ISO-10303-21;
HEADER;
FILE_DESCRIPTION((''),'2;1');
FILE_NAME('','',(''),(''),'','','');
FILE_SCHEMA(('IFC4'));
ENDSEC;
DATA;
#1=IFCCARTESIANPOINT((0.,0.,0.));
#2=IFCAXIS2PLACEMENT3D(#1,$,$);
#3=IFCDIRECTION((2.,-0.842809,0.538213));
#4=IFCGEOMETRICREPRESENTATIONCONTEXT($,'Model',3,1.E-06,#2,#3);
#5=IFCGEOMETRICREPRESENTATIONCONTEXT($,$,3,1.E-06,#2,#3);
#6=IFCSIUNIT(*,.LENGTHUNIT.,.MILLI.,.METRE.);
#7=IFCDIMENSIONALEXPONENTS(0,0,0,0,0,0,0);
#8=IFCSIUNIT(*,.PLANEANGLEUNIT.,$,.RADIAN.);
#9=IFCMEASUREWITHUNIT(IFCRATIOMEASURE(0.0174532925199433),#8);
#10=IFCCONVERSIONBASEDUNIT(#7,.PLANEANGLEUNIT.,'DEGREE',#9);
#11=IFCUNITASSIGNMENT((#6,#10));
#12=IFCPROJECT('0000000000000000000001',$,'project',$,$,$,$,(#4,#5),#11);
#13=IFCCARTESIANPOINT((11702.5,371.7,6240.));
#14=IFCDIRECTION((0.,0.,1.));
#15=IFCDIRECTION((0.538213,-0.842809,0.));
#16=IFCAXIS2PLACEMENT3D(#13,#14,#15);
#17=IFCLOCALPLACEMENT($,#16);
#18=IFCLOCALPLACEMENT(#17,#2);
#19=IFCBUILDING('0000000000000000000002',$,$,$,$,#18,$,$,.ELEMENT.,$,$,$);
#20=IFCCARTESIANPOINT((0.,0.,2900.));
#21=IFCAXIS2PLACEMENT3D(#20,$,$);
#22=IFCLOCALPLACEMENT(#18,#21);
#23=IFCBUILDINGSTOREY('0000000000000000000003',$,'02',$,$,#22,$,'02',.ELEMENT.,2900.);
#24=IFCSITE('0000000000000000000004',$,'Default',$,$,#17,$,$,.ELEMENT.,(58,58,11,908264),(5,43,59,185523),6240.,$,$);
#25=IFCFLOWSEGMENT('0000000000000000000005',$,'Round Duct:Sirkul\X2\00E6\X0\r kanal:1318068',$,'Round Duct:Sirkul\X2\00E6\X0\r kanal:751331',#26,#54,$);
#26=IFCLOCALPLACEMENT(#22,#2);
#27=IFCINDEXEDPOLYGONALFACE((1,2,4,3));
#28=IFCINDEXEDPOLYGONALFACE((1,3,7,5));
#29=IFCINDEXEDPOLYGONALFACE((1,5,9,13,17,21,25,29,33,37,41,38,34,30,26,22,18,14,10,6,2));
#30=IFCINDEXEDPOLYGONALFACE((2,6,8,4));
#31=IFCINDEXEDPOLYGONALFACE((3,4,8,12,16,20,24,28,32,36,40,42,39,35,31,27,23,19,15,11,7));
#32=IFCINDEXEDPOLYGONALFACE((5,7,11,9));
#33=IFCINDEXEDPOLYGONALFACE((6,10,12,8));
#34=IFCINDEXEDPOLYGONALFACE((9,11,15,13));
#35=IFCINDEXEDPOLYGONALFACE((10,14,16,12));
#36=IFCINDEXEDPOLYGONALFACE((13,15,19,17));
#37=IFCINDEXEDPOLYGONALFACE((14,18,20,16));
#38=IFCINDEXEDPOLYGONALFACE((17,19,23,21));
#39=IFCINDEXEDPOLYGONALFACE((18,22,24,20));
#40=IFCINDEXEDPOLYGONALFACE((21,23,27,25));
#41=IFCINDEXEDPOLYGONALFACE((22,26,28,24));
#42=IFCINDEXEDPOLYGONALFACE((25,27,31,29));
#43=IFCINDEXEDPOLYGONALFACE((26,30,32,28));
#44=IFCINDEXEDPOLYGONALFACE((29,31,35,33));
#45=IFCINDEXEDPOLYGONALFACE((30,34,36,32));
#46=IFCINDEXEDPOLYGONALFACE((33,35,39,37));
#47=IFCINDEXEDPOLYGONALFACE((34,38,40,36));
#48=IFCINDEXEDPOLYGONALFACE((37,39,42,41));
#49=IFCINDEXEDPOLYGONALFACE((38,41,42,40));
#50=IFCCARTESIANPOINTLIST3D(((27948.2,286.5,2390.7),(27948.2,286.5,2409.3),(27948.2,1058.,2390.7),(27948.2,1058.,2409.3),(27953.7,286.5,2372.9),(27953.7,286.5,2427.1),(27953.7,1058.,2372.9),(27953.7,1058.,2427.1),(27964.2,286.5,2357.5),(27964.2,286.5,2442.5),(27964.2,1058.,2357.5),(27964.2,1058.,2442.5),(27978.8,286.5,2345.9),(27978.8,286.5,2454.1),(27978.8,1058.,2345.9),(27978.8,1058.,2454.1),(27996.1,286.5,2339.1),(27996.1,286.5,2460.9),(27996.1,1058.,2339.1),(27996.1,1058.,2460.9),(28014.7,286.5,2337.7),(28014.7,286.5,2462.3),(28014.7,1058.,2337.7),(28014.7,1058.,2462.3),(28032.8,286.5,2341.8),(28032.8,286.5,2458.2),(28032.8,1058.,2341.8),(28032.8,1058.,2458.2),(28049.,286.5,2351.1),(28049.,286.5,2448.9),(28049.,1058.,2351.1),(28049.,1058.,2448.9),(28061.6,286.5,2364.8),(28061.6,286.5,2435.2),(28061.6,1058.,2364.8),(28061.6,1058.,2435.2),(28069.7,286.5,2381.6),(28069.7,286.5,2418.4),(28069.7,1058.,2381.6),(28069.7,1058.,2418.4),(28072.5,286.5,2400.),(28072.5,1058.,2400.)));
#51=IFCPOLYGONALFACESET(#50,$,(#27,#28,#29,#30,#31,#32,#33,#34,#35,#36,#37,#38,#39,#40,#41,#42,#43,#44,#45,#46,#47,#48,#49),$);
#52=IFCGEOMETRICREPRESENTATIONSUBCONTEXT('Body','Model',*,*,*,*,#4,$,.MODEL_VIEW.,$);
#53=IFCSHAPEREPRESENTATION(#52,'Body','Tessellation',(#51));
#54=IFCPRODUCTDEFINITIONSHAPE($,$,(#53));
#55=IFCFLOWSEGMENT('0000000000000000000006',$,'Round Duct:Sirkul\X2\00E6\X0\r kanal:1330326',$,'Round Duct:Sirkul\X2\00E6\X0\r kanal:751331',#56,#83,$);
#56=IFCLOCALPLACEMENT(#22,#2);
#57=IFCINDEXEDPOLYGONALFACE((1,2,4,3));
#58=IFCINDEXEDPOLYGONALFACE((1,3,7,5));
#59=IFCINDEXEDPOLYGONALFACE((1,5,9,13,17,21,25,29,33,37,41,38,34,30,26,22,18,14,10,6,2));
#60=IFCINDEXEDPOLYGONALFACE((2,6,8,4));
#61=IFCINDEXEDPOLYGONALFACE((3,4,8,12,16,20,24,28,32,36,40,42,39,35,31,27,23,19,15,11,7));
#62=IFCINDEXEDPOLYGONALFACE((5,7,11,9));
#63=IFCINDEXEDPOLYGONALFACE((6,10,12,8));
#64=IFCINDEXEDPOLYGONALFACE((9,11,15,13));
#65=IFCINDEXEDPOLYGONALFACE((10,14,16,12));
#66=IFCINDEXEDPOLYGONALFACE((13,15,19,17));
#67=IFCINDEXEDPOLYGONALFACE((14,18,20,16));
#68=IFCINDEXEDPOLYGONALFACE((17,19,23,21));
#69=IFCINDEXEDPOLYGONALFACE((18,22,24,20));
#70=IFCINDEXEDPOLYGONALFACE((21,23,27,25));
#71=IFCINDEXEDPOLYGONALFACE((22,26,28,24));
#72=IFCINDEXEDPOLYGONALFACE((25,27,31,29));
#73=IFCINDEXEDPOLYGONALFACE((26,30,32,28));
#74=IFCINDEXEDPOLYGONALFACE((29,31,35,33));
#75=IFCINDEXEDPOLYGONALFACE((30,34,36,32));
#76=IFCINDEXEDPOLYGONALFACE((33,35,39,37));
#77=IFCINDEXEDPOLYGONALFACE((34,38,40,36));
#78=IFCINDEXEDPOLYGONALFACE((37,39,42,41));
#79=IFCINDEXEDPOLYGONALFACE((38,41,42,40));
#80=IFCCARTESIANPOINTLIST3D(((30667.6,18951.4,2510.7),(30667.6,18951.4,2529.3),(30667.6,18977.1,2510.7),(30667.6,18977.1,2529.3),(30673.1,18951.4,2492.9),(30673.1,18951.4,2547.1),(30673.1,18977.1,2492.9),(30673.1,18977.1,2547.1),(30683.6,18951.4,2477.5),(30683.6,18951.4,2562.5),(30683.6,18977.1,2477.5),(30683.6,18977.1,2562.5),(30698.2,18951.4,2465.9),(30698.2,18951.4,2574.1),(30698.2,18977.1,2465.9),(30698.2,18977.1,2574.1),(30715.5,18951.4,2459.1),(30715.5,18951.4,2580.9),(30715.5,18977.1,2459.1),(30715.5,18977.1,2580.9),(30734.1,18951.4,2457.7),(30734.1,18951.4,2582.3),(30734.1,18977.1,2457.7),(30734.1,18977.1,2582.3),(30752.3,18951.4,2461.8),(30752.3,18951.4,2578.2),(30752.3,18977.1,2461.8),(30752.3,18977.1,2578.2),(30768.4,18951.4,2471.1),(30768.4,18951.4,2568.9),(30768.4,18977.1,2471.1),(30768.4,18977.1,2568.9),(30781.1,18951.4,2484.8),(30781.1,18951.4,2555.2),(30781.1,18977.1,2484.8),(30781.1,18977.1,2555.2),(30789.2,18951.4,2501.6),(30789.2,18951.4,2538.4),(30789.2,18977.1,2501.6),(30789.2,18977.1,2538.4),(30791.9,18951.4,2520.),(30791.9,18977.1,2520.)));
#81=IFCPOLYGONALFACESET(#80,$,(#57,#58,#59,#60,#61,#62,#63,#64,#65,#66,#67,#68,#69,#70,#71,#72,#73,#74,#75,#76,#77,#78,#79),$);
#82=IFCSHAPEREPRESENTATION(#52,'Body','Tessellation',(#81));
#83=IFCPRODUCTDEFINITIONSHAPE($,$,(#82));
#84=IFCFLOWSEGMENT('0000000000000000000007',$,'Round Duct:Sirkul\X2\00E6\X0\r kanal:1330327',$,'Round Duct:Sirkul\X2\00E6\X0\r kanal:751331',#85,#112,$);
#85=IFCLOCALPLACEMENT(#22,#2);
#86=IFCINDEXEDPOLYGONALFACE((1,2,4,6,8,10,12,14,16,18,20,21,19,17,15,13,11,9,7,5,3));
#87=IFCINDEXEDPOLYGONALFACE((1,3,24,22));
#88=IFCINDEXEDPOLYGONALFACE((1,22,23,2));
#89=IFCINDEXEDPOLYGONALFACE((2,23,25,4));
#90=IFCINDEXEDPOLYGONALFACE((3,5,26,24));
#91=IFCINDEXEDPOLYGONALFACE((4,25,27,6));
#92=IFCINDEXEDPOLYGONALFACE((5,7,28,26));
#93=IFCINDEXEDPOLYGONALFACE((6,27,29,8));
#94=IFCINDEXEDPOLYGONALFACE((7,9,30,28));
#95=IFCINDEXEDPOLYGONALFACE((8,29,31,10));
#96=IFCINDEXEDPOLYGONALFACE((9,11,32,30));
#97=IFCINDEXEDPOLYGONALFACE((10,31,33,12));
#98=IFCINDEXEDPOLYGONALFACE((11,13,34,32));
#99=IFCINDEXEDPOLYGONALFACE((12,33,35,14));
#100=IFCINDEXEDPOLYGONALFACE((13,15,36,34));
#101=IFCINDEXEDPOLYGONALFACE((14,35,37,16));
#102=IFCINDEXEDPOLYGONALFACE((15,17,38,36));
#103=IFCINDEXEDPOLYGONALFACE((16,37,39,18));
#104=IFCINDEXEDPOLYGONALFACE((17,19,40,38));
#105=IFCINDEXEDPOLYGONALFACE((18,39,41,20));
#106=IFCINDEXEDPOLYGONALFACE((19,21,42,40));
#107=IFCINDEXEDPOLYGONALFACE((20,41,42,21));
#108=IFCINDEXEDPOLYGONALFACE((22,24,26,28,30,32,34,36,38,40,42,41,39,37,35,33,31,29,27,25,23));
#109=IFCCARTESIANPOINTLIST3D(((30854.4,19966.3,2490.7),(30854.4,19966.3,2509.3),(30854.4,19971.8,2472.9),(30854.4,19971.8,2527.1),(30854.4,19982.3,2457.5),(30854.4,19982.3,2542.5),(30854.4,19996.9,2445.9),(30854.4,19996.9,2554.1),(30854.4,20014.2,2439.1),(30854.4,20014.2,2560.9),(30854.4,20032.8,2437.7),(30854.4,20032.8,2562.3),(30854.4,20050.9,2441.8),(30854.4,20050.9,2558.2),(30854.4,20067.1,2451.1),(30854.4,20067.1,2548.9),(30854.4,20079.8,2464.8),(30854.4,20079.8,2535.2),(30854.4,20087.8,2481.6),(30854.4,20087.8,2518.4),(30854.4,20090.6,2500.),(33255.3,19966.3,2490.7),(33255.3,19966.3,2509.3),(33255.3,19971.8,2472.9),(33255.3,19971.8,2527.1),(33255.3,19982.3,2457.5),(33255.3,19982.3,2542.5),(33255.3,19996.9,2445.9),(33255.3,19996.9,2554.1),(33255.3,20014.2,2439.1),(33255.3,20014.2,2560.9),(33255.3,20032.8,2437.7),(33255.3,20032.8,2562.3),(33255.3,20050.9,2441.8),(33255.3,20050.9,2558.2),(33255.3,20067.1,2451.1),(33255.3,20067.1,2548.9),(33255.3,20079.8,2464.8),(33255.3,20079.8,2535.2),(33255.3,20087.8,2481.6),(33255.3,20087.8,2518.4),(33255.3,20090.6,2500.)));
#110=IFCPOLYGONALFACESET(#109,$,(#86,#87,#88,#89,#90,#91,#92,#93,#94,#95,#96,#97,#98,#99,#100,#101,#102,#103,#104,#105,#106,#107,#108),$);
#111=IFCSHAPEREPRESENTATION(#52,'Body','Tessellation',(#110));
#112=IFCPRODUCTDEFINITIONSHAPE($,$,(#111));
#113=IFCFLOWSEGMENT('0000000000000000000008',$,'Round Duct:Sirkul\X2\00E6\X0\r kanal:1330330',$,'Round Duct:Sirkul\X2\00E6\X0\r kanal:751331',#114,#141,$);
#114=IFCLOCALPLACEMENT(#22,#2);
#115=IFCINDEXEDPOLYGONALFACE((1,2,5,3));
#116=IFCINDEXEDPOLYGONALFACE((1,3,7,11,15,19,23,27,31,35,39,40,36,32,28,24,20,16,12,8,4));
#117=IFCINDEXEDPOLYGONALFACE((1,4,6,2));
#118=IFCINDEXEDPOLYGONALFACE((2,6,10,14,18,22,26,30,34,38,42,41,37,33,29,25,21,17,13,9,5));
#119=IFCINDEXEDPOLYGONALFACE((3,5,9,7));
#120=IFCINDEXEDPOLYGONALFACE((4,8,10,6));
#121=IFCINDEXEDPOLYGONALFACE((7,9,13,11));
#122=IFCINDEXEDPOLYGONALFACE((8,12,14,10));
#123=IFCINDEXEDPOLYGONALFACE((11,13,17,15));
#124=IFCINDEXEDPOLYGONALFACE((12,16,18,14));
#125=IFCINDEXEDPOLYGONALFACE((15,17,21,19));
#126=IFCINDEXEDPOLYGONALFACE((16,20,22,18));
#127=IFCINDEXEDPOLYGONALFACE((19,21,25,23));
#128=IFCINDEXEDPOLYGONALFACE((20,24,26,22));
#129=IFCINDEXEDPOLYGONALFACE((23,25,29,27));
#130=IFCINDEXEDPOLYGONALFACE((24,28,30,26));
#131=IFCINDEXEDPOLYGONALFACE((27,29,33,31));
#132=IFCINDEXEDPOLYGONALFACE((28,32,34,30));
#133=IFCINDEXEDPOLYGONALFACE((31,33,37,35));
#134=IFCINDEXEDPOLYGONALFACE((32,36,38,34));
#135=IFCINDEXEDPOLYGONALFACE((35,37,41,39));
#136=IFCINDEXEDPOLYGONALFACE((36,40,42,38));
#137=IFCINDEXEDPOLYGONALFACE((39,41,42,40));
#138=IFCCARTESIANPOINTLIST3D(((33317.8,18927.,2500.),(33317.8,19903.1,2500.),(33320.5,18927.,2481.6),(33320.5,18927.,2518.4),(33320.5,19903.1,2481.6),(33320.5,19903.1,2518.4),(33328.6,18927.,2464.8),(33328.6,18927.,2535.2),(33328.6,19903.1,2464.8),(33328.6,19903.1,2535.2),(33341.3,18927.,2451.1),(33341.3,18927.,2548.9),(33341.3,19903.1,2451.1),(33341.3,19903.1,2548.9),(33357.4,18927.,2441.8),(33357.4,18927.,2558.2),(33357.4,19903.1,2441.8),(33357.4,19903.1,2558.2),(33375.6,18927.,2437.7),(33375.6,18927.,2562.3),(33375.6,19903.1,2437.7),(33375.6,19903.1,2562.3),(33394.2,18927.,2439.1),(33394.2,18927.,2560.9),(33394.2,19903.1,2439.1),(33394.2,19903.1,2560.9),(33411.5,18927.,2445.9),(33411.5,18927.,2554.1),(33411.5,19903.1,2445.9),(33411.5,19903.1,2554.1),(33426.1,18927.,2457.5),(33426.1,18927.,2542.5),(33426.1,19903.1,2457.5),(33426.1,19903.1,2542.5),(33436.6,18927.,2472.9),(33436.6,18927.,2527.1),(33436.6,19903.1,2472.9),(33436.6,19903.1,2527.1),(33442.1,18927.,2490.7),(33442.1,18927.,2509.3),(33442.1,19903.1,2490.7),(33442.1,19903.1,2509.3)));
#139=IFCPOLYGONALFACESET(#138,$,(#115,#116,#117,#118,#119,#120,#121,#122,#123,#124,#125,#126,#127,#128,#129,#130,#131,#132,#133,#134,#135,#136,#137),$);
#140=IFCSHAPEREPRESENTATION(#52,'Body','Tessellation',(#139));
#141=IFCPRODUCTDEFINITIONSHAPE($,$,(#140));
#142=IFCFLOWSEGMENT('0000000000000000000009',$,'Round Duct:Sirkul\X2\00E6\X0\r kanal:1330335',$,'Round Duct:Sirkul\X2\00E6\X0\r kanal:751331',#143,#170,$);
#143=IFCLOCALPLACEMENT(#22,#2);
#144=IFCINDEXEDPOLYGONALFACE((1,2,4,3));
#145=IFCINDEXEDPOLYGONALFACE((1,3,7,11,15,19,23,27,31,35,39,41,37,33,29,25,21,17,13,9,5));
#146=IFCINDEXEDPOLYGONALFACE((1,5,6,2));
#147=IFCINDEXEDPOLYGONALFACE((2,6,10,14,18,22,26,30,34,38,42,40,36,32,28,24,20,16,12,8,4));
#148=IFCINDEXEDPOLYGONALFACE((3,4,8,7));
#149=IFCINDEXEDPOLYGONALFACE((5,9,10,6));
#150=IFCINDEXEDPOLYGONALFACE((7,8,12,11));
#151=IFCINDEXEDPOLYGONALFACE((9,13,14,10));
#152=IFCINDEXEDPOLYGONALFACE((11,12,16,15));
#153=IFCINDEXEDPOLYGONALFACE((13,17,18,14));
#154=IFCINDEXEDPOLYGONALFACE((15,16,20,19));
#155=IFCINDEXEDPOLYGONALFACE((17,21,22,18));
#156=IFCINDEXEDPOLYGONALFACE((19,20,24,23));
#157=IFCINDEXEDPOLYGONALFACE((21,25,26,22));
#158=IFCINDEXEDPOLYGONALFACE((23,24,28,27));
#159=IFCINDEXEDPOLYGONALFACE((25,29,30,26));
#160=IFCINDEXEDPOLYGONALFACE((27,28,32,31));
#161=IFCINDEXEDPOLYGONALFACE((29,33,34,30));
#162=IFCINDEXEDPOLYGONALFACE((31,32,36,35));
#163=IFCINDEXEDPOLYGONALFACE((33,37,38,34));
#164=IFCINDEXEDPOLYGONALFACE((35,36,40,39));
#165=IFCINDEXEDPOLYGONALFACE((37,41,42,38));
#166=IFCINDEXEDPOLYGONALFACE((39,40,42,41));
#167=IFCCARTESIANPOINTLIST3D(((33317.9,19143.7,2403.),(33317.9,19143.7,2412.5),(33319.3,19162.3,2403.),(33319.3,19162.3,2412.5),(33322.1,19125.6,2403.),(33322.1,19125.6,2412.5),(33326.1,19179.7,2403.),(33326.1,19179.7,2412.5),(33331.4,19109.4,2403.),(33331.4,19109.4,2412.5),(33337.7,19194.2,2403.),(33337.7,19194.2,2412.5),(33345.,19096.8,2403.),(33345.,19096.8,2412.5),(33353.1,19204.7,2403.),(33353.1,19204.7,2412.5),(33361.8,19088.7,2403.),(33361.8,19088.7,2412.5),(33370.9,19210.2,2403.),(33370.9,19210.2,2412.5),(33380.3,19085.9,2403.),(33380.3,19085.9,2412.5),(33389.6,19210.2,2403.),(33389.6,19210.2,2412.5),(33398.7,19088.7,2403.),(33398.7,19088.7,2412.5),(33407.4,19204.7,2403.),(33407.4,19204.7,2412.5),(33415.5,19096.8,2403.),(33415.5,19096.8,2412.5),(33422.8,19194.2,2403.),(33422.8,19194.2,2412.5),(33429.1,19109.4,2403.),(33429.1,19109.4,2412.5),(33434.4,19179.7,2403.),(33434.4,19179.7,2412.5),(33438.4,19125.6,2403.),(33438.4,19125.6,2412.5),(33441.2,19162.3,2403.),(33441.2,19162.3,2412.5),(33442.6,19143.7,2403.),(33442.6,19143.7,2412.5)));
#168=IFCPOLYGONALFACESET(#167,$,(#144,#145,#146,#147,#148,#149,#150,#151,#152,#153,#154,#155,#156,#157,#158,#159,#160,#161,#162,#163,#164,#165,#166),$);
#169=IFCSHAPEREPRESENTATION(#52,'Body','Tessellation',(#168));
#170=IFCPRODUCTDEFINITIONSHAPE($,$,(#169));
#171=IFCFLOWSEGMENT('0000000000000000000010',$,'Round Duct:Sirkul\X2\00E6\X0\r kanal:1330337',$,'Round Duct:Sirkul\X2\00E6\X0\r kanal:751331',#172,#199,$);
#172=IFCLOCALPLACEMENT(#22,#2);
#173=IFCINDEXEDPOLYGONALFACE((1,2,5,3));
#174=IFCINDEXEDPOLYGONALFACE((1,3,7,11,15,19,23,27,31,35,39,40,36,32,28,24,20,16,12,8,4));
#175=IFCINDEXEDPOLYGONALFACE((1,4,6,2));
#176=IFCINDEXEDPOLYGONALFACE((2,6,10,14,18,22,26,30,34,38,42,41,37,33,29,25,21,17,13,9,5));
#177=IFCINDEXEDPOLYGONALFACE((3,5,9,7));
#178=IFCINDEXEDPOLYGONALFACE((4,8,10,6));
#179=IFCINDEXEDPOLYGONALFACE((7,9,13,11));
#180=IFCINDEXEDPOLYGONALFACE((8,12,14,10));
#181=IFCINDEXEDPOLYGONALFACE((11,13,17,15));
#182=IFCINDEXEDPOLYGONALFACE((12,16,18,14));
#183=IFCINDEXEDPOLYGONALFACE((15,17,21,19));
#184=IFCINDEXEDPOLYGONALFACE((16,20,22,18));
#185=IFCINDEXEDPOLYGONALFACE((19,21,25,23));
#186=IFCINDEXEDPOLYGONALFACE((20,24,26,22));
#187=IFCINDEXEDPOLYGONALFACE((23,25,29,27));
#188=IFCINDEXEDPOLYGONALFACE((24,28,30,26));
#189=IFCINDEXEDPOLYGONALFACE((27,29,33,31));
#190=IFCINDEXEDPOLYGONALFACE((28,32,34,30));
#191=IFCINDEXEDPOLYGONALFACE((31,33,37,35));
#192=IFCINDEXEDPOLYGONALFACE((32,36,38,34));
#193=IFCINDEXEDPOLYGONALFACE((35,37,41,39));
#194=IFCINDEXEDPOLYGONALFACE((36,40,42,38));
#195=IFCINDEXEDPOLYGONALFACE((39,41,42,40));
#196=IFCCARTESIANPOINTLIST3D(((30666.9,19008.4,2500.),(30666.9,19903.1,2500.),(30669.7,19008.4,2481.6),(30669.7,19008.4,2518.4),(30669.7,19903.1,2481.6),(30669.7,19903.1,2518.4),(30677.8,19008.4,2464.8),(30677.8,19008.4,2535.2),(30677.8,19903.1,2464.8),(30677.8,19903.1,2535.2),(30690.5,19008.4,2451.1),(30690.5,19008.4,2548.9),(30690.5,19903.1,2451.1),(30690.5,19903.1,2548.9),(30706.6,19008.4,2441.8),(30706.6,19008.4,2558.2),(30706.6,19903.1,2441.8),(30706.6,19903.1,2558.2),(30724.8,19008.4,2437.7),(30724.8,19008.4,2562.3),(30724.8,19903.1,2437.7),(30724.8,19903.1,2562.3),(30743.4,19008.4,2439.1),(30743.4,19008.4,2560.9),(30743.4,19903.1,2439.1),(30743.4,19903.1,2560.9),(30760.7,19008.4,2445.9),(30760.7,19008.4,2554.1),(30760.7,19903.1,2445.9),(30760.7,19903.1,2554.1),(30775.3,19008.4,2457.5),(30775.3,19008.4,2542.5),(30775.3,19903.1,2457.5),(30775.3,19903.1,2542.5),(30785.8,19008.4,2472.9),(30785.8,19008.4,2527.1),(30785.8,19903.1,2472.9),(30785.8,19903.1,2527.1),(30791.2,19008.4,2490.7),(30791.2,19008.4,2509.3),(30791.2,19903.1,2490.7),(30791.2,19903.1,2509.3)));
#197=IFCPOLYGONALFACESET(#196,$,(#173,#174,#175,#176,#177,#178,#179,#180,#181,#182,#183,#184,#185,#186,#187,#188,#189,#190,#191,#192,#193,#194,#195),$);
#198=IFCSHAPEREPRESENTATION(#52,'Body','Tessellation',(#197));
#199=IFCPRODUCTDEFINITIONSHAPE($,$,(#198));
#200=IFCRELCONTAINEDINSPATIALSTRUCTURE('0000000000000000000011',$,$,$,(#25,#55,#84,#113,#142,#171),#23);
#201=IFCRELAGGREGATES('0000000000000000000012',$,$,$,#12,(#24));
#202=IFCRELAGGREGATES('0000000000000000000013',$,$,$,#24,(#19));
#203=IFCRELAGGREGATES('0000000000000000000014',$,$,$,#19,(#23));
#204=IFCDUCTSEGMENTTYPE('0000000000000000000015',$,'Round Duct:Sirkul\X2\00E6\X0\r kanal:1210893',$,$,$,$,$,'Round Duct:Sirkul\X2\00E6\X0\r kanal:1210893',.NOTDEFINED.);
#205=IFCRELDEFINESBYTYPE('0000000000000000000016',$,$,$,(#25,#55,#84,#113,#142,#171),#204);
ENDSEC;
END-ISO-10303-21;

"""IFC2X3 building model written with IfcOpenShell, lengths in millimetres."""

from ifc_helpers import new_model, entity, si_unit, converted_unit, direction, frame, frame_2d, origin, origin_2d_with_axis, place, context, subcontext, project, spatial, circle, extrude, type_object, element, save


model = new_model("IFC2X3")

# Units and contexts
model_context = context("Model", 3, precision=1e-06, world=origin(), true_north=direction((2.0, -0.842809, 0.538213)))
context_of_model = context(None, 3, precision=1e-06, world=origin(), true_north=direction((2.0, -0.842809, 0.538213)))
body_context = subcontext(model_context, "Body", "Model", "MODEL_VIEW")
ifc_project = project(units=[si_unit("LENGTHUNIT", "METRE", prefix="MILLI"), converted_unit("PLANEANGLEUNIT", "DEGREE", entity("IfcRatioMeasure", 0.0174532925199433), si_unit("PLANEANGLEUNIT", "RADIAN"), dimensions=[0, 0, 0, 0, 0, 0, 0])], contexts=[model_context, context_of_model])

# Site, building, storey
site_placement = place(None, frame((11702.5, 371.7, 6240.0), z_axis=(0.0, 0.0, 1.0), x_axis=(0.538213, -0.842809, 0.0)))
site = spatial("IfcSite", under=ifc_project, at=site_placement, Name="Default", CompositionType="ELEMENT", RefLatitude=(58, 58, 11, 908264), RefLongitude=(5, 43, 59, 185523), RefElevation=6240.0)
building_placement = place(site_placement, origin())
building = spatial("IfcBuilding", under=site, at=building_placement, CompositionType="ELEMENT")
storey_placement = place(building_placement, frame((0.0, 0.0, 2900.0)))
storey = spatial("IfcBuildingStorey", under=building, at=storey_placement, Name="02", LongName="02", CompositionType="ELEMENT", Elevation=2900.0)

# Flow segments
duct_segment_type_1 = type_object("IfcDuctSegmentType", Name="Round Duct:Sirkulær kanal:1210893", ElementType="Round Duct:Sirkulær kanal:1210893", PredefinedType="NOTDEFINED")
flow_segment_1_placement = place(storey_placement, origin())
element("IfcFlowSegment", 1, at=flow_segment_1_placement, inside=storey, type_object=duct_segment_type_1, Name="Round Duct:Sirkulær kanal:1318068", ObjectType="Round Duct:Sirkulær kanal:751331", context=body_context, shape_type="SweptSolid", body=[
    extrude(circle(Radius=62.5, at=frame_2d((0.0, 0.0), x_axis=(1.0, 0.0))), frame((28010.0, 286.5, 2400.0), z_axis=(0.0, 1.0, 0.0), x_axis=(1.0, 0.0, 0.0)), (0.0, 0.0, 1.0), 771.5),
])
flow_segment_2_placement = place(storey_placement, origin())
element("IfcFlowSegment", 2, at=flow_segment_2_placement, inside=storey, type_object=duct_segment_type_1, Name="Round Duct:Sirkulær kanal:1330326", ObjectType="Round Duct:Sirkulær kanal:751331", context=body_context, shape_type="SweptSolid", body=[
    extrude(circle(Radius=62.5, at=origin_2d_with_axis()), frame((30729.4, 18951.4, 2520.0), z_axis=(0.0, 1.0, 0.0), x_axis=(1.0, 0.0, 0.0)), (0.0, 0.0, 1.0), 25.7),
])
flow_segment_3_placement = place(storey_placement, origin())
element("IfcFlowSegment", 3, at=flow_segment_3_placement, inside=storey, type_object=duct_segment_type_1, Name="Round Duct:Sirkulær kanal:1330327", ObjectType="Round Duct:Sirkulær kanal:751331", context=body_context, shape_type="SweptSolid", body=[
    extrude(circle(Radius=62.5, at=origin_2d_with_axis()), frame((30854.4, 20028.1, 2500.0), z_axis=(1.0, 0.0, 0.0), x_axis=(0.0, 1.0, 0.0)), (0.0, 0.0, 1.0), 2400.8),
])
flow_segment_4_placement = place(storey_placement, origin())
element("IfcFlowSegment", 4, at=flow_segment_4_placement, inside=storey, type_object=duct_segment_type_1, Name="Round Duct:Sirkulær kanal:1330330", ObjectType="Round Duct:Sirkulær kanal:751331", context=body_context, shape_type="SweptSolid", body=[
    extrude(circle(Radius=62.5, at=origin_2d_with_axis()), frame((33380.3, 18927.0, 2500.0), z_axis=(0.0, 1.0, 0.0), x_axis=(-1.0, 0.0, 0.0)), (0.0, 0.0, 1.0), 976.1),
])
flow_segment_5_placement = place(storey_placement, origin())
element("IfcFlowSegment", 5, at=flow_segment_5_placement, inside=storey, type_object=duct_segment_type_1, Name="Round Duct:Sirkulær kanal:1330335", ObjectType="Round Duct:Sirkulær kanal:751331", context=body_context, shape_type="SweptSolid", body=[
    extrude(circle(Radius=62.5, at=frame_2d((0.0, 0.0), x_axis=(1.0, 0.0))), frame((33380.3, 19148.4, 2403.0), z_axis=(0.0, 0.0, 1.0), x_axis=(0.0, -1.0, 0.0)), (0.0, 0.0, 1.0), 9.5),
])
flow_segment_6_placement = place(storey_placement, origin())
element("IfcFlowSegment", 6, at=flow_segment_6_placement, inside=storey, type_object=duct_segment_type_1, Name="Round Duct:Sirkulær kanal:1330337", ObjectType="Round Duct:Sirkulær kanal:751331", context=body_context, shape_type="SweptSolid", body=[
    extrude(circle(Radius=62.5, at=frame_2d((0.0, 0.0), x_axis=(1.0, 0.0))), frame((30729.4, 19008.4, 2500.0), z_axis=(0.0, 1.0, 0.0), x_axis=(-1.0, 0.0, 0.0)), (0.0, 0.0, 1.0), 894.7),
])

save(model, "model.ifc")
